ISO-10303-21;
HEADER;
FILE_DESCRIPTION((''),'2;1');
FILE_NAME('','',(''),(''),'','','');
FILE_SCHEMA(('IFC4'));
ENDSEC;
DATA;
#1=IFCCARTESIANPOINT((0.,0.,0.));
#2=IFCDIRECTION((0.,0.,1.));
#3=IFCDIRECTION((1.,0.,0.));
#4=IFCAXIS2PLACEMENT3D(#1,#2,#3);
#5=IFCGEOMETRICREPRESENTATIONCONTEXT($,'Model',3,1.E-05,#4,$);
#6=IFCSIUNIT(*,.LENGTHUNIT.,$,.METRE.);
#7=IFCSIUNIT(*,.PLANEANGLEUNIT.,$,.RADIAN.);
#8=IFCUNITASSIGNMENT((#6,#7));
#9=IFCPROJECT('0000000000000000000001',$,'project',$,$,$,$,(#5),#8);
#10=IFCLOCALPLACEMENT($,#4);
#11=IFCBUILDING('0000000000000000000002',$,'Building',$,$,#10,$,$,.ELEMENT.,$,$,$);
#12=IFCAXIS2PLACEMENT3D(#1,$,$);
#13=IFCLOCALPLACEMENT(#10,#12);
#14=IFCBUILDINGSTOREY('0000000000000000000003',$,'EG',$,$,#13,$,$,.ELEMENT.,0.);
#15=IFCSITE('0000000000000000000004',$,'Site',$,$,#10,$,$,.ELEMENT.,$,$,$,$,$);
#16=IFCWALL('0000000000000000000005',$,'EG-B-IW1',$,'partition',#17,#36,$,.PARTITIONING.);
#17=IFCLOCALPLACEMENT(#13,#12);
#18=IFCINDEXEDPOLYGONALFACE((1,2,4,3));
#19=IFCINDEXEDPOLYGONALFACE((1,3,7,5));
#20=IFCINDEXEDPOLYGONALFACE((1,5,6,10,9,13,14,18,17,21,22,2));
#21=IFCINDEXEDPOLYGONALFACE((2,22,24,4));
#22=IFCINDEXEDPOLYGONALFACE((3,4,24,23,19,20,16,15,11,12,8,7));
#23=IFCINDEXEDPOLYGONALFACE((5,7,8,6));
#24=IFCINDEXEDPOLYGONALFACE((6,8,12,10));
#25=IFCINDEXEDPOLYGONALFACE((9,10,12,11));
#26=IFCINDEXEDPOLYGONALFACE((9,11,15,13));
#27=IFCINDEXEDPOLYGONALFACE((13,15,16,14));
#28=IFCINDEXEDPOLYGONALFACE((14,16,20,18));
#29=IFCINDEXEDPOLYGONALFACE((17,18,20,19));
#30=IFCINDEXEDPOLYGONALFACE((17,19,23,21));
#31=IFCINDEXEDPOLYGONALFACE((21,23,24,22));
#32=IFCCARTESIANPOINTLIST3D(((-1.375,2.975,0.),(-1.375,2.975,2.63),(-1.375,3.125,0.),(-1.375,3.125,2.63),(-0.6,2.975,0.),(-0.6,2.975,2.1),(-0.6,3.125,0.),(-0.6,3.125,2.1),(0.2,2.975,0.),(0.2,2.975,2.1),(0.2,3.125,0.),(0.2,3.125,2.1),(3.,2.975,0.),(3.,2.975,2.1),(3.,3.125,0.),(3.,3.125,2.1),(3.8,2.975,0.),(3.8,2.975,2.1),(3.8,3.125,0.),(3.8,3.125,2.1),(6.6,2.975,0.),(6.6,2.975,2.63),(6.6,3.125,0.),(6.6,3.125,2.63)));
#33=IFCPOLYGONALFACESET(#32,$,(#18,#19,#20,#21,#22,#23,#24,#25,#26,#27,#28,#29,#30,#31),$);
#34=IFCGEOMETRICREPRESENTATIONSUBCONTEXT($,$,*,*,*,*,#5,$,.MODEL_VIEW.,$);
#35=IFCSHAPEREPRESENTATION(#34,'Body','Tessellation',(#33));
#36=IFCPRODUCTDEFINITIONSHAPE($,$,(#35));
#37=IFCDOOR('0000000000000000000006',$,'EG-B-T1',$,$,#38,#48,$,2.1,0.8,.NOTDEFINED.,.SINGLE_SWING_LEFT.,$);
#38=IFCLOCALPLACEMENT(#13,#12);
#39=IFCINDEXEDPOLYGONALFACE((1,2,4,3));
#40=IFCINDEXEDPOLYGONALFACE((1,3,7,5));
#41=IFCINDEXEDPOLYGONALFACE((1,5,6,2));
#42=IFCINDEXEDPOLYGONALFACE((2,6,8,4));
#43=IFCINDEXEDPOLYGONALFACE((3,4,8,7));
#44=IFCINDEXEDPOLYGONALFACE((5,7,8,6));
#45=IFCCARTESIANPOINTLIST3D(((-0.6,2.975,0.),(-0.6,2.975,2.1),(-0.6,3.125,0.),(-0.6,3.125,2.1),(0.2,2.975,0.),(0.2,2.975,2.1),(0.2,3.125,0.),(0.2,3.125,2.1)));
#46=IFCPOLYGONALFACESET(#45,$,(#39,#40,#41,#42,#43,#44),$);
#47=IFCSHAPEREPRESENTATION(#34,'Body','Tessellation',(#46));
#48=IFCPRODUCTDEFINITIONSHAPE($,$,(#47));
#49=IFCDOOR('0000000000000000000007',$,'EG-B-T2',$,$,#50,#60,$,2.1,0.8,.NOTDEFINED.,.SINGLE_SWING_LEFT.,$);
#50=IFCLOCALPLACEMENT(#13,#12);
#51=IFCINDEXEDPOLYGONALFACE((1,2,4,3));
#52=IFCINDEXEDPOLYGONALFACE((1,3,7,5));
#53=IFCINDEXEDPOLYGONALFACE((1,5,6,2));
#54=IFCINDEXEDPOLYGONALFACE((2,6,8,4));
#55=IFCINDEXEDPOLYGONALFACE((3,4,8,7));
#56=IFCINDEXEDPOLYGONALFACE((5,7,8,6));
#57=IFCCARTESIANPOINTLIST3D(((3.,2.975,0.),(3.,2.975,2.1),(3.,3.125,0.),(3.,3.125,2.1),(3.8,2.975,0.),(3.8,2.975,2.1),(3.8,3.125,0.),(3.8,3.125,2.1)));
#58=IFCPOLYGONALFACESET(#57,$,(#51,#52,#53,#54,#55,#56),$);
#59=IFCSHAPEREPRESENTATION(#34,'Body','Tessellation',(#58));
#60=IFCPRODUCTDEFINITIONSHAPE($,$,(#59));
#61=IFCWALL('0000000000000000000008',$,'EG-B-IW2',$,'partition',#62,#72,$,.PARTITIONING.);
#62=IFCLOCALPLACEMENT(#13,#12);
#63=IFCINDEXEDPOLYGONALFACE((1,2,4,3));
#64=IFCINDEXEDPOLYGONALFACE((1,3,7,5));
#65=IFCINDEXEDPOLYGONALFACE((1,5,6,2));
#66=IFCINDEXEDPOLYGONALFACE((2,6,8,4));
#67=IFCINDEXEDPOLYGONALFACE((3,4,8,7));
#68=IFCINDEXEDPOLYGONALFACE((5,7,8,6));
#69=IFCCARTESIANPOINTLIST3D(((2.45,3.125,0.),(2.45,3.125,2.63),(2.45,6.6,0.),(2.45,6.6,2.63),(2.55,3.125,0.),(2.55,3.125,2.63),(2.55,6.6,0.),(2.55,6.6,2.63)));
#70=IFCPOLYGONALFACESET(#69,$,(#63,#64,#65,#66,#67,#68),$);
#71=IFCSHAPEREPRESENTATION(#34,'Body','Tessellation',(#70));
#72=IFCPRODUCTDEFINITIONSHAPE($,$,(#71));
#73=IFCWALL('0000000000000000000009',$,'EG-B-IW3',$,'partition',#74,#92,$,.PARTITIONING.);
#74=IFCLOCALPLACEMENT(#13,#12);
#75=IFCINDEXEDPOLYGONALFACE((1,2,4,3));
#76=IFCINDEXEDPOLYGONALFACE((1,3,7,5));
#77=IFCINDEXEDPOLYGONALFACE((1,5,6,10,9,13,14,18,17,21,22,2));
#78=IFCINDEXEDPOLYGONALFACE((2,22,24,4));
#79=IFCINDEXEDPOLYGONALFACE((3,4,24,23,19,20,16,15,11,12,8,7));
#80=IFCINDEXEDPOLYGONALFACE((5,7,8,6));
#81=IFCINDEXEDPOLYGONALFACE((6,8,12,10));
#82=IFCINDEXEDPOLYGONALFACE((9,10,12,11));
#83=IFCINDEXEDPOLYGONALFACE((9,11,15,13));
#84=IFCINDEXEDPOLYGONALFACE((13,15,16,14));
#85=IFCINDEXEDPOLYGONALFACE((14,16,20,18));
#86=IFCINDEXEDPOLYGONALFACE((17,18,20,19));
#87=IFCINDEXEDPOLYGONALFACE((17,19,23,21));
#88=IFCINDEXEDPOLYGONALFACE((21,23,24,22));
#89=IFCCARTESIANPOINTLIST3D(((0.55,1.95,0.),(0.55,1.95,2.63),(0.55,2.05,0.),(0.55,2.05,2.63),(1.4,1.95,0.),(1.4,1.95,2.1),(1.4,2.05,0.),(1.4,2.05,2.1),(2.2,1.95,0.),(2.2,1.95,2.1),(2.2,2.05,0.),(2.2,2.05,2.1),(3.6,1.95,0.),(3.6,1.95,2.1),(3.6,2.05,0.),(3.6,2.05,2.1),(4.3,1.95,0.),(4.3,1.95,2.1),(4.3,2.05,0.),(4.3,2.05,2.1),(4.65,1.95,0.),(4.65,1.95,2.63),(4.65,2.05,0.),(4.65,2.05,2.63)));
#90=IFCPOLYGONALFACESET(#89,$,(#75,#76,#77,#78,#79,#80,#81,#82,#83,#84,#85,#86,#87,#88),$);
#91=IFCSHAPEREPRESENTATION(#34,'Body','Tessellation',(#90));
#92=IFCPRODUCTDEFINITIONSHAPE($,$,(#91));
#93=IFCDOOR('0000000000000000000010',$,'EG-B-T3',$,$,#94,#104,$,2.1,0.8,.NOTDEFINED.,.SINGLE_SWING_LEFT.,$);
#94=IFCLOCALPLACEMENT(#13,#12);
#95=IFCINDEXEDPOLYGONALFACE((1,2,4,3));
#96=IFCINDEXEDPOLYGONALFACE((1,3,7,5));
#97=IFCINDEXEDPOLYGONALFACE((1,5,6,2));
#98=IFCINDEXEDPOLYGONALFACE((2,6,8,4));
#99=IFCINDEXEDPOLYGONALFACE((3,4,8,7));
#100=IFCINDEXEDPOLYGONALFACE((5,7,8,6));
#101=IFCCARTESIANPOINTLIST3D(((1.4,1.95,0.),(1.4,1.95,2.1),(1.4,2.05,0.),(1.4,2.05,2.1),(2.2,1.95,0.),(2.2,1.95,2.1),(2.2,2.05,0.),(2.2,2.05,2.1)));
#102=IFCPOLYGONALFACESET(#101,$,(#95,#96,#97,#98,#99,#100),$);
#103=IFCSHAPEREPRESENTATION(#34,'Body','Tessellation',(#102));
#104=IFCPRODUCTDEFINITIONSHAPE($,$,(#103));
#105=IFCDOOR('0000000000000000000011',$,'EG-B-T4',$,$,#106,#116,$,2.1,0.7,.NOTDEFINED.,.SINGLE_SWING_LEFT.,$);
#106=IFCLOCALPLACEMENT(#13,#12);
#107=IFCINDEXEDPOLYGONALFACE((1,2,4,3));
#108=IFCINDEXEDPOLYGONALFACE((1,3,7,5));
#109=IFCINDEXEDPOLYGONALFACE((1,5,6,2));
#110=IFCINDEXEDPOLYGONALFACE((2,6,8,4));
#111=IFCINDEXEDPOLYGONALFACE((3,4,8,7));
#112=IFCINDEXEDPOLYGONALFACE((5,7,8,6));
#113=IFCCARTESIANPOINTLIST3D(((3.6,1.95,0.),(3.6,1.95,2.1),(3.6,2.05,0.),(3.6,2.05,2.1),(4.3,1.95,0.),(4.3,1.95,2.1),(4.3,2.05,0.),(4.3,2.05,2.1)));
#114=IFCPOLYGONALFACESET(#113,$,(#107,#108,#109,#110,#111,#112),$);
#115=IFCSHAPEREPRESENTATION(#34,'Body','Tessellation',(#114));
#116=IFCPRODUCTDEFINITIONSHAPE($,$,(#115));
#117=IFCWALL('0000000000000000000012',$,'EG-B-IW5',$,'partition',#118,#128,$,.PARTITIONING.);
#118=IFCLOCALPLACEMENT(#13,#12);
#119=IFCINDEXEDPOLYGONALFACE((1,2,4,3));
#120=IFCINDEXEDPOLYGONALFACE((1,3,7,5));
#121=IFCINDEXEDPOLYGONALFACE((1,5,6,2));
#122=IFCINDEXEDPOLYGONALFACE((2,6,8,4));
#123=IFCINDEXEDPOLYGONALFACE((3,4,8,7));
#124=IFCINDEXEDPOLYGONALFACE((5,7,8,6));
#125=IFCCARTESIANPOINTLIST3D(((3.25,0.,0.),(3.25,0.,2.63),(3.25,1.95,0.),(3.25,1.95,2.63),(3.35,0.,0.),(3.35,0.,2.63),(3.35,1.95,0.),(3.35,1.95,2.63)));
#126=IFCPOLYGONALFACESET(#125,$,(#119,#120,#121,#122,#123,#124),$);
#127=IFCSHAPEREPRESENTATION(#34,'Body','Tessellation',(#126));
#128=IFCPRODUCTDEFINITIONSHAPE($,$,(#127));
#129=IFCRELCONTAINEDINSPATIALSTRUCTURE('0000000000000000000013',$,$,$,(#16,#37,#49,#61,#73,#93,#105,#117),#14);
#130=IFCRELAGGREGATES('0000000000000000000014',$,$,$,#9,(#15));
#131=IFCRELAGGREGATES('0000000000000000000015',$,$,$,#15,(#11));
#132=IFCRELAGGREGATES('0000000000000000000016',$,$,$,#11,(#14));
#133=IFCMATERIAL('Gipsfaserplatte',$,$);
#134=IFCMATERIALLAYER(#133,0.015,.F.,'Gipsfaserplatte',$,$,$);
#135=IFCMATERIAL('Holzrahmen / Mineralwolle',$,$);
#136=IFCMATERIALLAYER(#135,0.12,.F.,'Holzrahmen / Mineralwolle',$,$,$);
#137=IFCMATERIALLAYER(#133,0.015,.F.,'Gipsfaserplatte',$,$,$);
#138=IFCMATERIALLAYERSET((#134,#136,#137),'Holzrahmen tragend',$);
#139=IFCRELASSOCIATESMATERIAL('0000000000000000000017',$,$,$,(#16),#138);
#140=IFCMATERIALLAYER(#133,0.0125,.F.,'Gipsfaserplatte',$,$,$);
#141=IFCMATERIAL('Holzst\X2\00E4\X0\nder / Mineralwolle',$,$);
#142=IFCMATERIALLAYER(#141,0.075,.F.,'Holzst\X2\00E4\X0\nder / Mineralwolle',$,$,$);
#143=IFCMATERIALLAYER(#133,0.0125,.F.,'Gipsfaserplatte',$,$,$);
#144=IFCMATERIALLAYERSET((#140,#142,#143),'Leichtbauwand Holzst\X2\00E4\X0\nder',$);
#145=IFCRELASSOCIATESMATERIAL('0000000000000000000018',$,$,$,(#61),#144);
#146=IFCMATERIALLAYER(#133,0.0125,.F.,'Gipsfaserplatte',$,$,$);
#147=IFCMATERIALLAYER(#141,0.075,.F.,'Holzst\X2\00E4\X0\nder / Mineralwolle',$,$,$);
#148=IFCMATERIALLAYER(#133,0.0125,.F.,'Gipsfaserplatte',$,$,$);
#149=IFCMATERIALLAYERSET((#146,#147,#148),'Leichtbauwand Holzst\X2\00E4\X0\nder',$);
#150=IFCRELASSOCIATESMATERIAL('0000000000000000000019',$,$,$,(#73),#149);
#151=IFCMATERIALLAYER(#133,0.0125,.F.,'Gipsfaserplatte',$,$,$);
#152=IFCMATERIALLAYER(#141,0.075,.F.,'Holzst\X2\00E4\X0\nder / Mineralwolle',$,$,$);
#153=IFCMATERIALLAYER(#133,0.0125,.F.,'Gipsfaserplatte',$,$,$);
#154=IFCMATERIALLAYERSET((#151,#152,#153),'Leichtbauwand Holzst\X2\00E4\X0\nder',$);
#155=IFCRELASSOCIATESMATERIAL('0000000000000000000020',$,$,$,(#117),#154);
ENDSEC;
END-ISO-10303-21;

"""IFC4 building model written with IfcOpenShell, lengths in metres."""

from ifc_helpers import new_model, si_unit, frame, frame_2d, origin, origin_with_axes, place, context, subcontext, project, spatial, rectangle, extrude, material, layer, layer_set, element, fill, save


model = new_model("IFC4")

# Units and contexts
model_context = context("Model", 3, precision=1e-05, world=origin_with_axes())
sub_context = subcontext(model_context, None, None, "MODEL_VIEW")
ifc_project = project(units=[si_unit("LENGTHUNIT", "METRE"), si_unit("PLANEANGLEUNIT", "RADIAN")], contexts=[model_context])

# Site, building, storey
placement = place(None, origin_with_axes())
site = spatial("IfcSite", under=ifc_project, at=placement, Name="Site", CompositionType="ELEMENT")
building = spatial("IfcBuilding", under=site, at=placement, Name="Building", CompositionType="ELEMENT")
storey_placement = place(placement, origin())
storey = spatial("IfcBuildingStorey", under=building, at=storey_placement, Name="EG", CompositionType="ELEMENT", Elevation=0.0)

# Shared definitions
ifc_material_1 = material(Name="Gipsfaserplatte")
ifc_material_2 = material(Name="Holzrahmen / Mineralwolle")

# Wall, openings, doors
ifc_layer_1 = layer(ifc_material_1, 0.015, ventilated=False, Name="Gipsfaserplatte")
ifc_layer_2 = layer(ifc_material_2, 0.12, ventilated=False, Name="Holzrahmen / Mineralwolle")
ifc_layer_3 = layer(ifc_material_1, 0.015, ventilated=False, Name="Gipsfaserplatte")
ifc_layer_set_1 = layer_set([ifc_layer_1, ifc_layer_2, ifc_layer_3], Name="Holzrahmen tragend")
wall_1_placement = place(storey_placement, frame((-1.375, 3.05, 0.0), z_axis=(0.0, 0.0, 1.0), x_axis=(1.0, 0.0, 0.0)))
wall_1 = element("IfcWall", 1, at=wall_1_placement, inside=storey, material=ifc_layer_set_1, Name="EG-B-IW1", ObjectType="partition", PredefinedType="PARTITIONING", context=sub_context, shape_type="SweptSolid", body=[
    extrude(rectangle(XDim=7.975, YDim=0.15, at=frame_2d((3.9875, 0.0))), origin(), (0.0, 0.0, 1.0), 2.63),
])
opening_1_placement = place(wall_1_placement, frame((1.175, 0.125, 0.0), z_axis=(0.0, -1.0, 0.0), x_axis=(1.0, 0.0, 0.0)))
opening_1 = element("IfcOpeningElement", 2, at=opening_1_placement, cuts=wall_1, PredefinedType="OPENING", context=sub_context, shape_type="SweptSolid", body=[
    extrude(rectangle(XDim=0.8, YDim=2.1, at=frame_2d((0.0, 1.05))), origin(), (0.0, 0.0, 1.0), 0.25),
])
opening_2_placement = place(wall_1_placement, frame((4.775, 0.125, 0.0), z_axis=(0.0, -1.0, 0.0), x_axis=(1.0, 0.0, 0.0)))
opening_2 = element("IfcOpeningElement", 3, at=opening_2_placement, cuts=wall_1, PredefinedType="OPENING", context=sub_context, shape_type="SweptSolid", body=[
    extrude(rectangle(XDim=0.8, YDim=2.1, at=frame_2d((0.0, 1.05))), origin(), (0.0, 0.0, 1.0), 0.25),
])
door_1_placement = place(wall_1_placement, frame((1.175, 0.075, 0.0), z_axis=(0.0, -1.0, 0.0), x_axis=(1.0, 0.0, 0.0)))
door_1 = element("IfcDoor", 4, at=door_1_placement, inside=storey, Name="EG-B-T1", OperationType="SINGLE_SWING_LEFT", OverallHeight=2.1, OverallWidth=0.8, PredefinedType="NOTDEFINED", context=sub_context, shape_type="SweptSolid", body=[
    extrude(rectangle(XDim=0.8, YDim=2.1, at=frame_2d((0.0, 1.05))), origin(), (0.0, 0.0, 1.0), 0.15),
])
fill(opening_1, door_1)
door_2_placement = place(wall_1_placement, frame((4.775, 0.075, 0.0), z_axis=(0.0, -1.0, 0.0), x_axis=(1.0, 0.0, 0.0)))
door_2 = element("IfcDoor", 5, at=door_2_placement, inside=storey, Name="EG-B-T2", OperationType="SINGLE_SWING_LEFT", OverallHeight=2.1, OverallWidth=0.8, PredefinedType="NOTDEFINED", context=sub_context, shape_type="SweptSolid", body=[
    extrude(rectangle(XDim=0.8, YDim=2.1, at=frame_2d((0.0, 1.05))), origin(), (0.0, 0.0, 1.0), 0.15),
])
fill(opening_2, door_2)

# Wall
ifc_layer_4 = layer(ifc_material_1, 0.0125, ventilated=False, Name="Gipsfaserplatte")
ifc_material_3 = material(Name="Holzständer / Mineralwolle")
ifc_layer_5 = layer(ifc_material_3, 0.075, ventilated=False, Name="Holzständer / Mineralwolle")
ifc_layer_6 = layer(ifc_material_1, 0.0125, ventilated=False, Name="Gipsfaserplatte")
ifc_layer_set_2 = layer_set([ifc_layer_4, ifc_layer_5, ifc_layer_6], Name="Leichtbauwand Holzständer")
wall_2_placement = place(storey_placement, frame((2.5, 3.125, 0.0), z_axis=(0.0, 0.0, 1.0), x_axis=(0.0, 1.0, 0.0)))
element("IfcWall", 6, at=wall_2_placement, inside=storey, material=ifc_layer_set_2, Name="EG-B-IW2", ObjectType="partition", PredefinedType="PARTITIONING", context=sub_context, shape_type="SweptSolid", body=[
    extrude(rectangle(XDim=3.475, YDim=0.1, at=frame_2d((1.7375, 0.0))), origin(), (0.0, 0.0, 1.0), 2.63),
])

# Wall, openings, doors
ifc_layer_7 = layer(ifc_material_1, 0.0125, ventilated=False, Name="Gipsfaserplatte")
ifc_layer_8 = layer(ifc_material_3, 0.075, ventilated=False, Name="Holzständer / Mineralwolle")
ifc_layer_9 = layer(ifc_material_1, 0.0125, ventilated=False, Name="Gipsfaserplatte")
ifc_layer_set_3 = layer_set([ifc_layer_7, ifc_layer_8, ifc_layer_9], Name="Leichtbauwand Holzständer")
wall_3_placement = place(storey_placement, frame((0.55, 2.0, 0.0), z_axis=(0.0, 0.0, 1.0), x_axis=(1.0, 0.0, 0.0)))
wall_3 = element("IfcWall", 7, at=wall_3_placement, inside=storey, material=ifc_layer_set_3, Name="EG-B-IW3", ObjectType="partition", PredefinedType="PARTITIONING", context=sub_context, shape_type="SweptSolid", body=[
    extrude(rectangle(XDim=4.1, YDim=0.1, at=frame_2d((2.05, 0.0))), origin(), (0.0, 0.0, 1.0), 2.63),
])
opening_3_placement = place(wall_3_placement, frame((1.25, 0.1, 0.0), z_axis=(0.0, -1.0, 0.0), x_axis=(1.0, 0.0, 0.0)))
opening_3 = element("IfcOpeningElement", 8, at=opening_3_placement, cuts=wall_3, PredefinedType="OPENING", context=sub_context, shape_type="SweptSolid", body=[
    extrude(rectangle(XDim=0.8, YDim=2.1, at=frame_2d((0.0, 1.05))), origin(), (0.0, 0.0, 1.0), 0.2),
])
opening_4_placement = place(wall_3_placement, frame((3.4, 0.1, 0.0), z_axis=(0.0, -1.0, 0.0), x_axis=(1.0, 0.0, 0.0)))
opening_4 = element("IfcOpeningElement", 9, at=opening_4_placement, cuts=wall_3, PredefinedType="OPENING", context=sub_context, shape_type="SweptSolid", body=[
    extrude(rectangle(XDim=0.7, YDim=2.1, at=frame_2d((0.0, 1.05))), origin(), (0.0, 0.0, 1.0), 0.2),
])
door_3_placement = place(wall_3_placement, frame((1.25, 0.05, 0.0), z_axis=(0.0, -1.0, 0.0), x_axis=(1.0, 0.0, 0.0)))
door_3 = element("IfcDoor", 10, at=door_3_placement, inside=storey, Name="EG-B-T3", OperationType="SINGLE_SWING_LEFT", OverallHeight=2.1, OverallWidth=0.8, PredefinedType="NOTDEFINED", context=sub_context, shape_type="SweptSolid", body=[
    extrude(rectangle(XDim=0.8, YDim=2.1, at=frame_2d((0.0, 1.05))), origin(), (0.0, 0.0, 1.0), 0.1),
])
fill(opening_3, door_3)
door_4_placement = place(wall_3_placement, frame((3.4, 0.05, 0.0), z_axis=(0.0, -1.0, 0.0), x_axis=(1.0, 0.0, 0.0)))
door_4 = element("IfcDoor", 11, at=door_4_placement, inside=storey, Name="EG-B-T4", OperationType="SINGLE_SWING_LEFT", OverallHeight=2.1, OverallWidth=0.7, PredefinedType="NOTDEFINED", context=sub_context, shape_type="SweptSolid", body=[
    extrude(rectangle(XDim=0.7, YDim=2.1, at=frame_2d((0.0, 1.05))), origin(), (0.0, 0.0, 1.0), 0.1),
])
fill(opening_4, door_4)

# Wall
ifc_layer_10 = layer(ifc_material_1, 0.0125, ventilated=False, Name="Gipsfaserplatte")
ifc_layer_11 = layer(ifc_material_3, 0.075, ventilated=False, Name="Holzständer / Mineralwolle")
ifc_layer_12 = layer(ifc_material_1, 0.0125, ventilated=False, Name="Gipsfaserplatte")
ifc_layer_set_4 = layer_set([ifc_layer_10, ifc_layer_11, ifc_layer_12], Name="Leichtbauwand Holzständer")
wall_4_placement = place(storey_placement, frame((3.3, 0.0, 0.0), z_axis=(0.0, 0.0, 1.0), x_axis=(0.0, 1.0, 0.0)))
element("IfcWall", 12, at=wall_4_placement, inside=storey, material=ifc_layer_set_4, Name="EG-B-IW5", ObjectType="partition", PredefinedType="PARTITIONING", context=sub_context, shape_type="SweptSolid", body=[
    extrude(rectangle(XDim=1.95, YDim=0.1, at=frame_2d((0.975, 0.0))), origin(), (0.0, 0.0, 1.0), 2.63),
])

save(model, "model.ifc")
